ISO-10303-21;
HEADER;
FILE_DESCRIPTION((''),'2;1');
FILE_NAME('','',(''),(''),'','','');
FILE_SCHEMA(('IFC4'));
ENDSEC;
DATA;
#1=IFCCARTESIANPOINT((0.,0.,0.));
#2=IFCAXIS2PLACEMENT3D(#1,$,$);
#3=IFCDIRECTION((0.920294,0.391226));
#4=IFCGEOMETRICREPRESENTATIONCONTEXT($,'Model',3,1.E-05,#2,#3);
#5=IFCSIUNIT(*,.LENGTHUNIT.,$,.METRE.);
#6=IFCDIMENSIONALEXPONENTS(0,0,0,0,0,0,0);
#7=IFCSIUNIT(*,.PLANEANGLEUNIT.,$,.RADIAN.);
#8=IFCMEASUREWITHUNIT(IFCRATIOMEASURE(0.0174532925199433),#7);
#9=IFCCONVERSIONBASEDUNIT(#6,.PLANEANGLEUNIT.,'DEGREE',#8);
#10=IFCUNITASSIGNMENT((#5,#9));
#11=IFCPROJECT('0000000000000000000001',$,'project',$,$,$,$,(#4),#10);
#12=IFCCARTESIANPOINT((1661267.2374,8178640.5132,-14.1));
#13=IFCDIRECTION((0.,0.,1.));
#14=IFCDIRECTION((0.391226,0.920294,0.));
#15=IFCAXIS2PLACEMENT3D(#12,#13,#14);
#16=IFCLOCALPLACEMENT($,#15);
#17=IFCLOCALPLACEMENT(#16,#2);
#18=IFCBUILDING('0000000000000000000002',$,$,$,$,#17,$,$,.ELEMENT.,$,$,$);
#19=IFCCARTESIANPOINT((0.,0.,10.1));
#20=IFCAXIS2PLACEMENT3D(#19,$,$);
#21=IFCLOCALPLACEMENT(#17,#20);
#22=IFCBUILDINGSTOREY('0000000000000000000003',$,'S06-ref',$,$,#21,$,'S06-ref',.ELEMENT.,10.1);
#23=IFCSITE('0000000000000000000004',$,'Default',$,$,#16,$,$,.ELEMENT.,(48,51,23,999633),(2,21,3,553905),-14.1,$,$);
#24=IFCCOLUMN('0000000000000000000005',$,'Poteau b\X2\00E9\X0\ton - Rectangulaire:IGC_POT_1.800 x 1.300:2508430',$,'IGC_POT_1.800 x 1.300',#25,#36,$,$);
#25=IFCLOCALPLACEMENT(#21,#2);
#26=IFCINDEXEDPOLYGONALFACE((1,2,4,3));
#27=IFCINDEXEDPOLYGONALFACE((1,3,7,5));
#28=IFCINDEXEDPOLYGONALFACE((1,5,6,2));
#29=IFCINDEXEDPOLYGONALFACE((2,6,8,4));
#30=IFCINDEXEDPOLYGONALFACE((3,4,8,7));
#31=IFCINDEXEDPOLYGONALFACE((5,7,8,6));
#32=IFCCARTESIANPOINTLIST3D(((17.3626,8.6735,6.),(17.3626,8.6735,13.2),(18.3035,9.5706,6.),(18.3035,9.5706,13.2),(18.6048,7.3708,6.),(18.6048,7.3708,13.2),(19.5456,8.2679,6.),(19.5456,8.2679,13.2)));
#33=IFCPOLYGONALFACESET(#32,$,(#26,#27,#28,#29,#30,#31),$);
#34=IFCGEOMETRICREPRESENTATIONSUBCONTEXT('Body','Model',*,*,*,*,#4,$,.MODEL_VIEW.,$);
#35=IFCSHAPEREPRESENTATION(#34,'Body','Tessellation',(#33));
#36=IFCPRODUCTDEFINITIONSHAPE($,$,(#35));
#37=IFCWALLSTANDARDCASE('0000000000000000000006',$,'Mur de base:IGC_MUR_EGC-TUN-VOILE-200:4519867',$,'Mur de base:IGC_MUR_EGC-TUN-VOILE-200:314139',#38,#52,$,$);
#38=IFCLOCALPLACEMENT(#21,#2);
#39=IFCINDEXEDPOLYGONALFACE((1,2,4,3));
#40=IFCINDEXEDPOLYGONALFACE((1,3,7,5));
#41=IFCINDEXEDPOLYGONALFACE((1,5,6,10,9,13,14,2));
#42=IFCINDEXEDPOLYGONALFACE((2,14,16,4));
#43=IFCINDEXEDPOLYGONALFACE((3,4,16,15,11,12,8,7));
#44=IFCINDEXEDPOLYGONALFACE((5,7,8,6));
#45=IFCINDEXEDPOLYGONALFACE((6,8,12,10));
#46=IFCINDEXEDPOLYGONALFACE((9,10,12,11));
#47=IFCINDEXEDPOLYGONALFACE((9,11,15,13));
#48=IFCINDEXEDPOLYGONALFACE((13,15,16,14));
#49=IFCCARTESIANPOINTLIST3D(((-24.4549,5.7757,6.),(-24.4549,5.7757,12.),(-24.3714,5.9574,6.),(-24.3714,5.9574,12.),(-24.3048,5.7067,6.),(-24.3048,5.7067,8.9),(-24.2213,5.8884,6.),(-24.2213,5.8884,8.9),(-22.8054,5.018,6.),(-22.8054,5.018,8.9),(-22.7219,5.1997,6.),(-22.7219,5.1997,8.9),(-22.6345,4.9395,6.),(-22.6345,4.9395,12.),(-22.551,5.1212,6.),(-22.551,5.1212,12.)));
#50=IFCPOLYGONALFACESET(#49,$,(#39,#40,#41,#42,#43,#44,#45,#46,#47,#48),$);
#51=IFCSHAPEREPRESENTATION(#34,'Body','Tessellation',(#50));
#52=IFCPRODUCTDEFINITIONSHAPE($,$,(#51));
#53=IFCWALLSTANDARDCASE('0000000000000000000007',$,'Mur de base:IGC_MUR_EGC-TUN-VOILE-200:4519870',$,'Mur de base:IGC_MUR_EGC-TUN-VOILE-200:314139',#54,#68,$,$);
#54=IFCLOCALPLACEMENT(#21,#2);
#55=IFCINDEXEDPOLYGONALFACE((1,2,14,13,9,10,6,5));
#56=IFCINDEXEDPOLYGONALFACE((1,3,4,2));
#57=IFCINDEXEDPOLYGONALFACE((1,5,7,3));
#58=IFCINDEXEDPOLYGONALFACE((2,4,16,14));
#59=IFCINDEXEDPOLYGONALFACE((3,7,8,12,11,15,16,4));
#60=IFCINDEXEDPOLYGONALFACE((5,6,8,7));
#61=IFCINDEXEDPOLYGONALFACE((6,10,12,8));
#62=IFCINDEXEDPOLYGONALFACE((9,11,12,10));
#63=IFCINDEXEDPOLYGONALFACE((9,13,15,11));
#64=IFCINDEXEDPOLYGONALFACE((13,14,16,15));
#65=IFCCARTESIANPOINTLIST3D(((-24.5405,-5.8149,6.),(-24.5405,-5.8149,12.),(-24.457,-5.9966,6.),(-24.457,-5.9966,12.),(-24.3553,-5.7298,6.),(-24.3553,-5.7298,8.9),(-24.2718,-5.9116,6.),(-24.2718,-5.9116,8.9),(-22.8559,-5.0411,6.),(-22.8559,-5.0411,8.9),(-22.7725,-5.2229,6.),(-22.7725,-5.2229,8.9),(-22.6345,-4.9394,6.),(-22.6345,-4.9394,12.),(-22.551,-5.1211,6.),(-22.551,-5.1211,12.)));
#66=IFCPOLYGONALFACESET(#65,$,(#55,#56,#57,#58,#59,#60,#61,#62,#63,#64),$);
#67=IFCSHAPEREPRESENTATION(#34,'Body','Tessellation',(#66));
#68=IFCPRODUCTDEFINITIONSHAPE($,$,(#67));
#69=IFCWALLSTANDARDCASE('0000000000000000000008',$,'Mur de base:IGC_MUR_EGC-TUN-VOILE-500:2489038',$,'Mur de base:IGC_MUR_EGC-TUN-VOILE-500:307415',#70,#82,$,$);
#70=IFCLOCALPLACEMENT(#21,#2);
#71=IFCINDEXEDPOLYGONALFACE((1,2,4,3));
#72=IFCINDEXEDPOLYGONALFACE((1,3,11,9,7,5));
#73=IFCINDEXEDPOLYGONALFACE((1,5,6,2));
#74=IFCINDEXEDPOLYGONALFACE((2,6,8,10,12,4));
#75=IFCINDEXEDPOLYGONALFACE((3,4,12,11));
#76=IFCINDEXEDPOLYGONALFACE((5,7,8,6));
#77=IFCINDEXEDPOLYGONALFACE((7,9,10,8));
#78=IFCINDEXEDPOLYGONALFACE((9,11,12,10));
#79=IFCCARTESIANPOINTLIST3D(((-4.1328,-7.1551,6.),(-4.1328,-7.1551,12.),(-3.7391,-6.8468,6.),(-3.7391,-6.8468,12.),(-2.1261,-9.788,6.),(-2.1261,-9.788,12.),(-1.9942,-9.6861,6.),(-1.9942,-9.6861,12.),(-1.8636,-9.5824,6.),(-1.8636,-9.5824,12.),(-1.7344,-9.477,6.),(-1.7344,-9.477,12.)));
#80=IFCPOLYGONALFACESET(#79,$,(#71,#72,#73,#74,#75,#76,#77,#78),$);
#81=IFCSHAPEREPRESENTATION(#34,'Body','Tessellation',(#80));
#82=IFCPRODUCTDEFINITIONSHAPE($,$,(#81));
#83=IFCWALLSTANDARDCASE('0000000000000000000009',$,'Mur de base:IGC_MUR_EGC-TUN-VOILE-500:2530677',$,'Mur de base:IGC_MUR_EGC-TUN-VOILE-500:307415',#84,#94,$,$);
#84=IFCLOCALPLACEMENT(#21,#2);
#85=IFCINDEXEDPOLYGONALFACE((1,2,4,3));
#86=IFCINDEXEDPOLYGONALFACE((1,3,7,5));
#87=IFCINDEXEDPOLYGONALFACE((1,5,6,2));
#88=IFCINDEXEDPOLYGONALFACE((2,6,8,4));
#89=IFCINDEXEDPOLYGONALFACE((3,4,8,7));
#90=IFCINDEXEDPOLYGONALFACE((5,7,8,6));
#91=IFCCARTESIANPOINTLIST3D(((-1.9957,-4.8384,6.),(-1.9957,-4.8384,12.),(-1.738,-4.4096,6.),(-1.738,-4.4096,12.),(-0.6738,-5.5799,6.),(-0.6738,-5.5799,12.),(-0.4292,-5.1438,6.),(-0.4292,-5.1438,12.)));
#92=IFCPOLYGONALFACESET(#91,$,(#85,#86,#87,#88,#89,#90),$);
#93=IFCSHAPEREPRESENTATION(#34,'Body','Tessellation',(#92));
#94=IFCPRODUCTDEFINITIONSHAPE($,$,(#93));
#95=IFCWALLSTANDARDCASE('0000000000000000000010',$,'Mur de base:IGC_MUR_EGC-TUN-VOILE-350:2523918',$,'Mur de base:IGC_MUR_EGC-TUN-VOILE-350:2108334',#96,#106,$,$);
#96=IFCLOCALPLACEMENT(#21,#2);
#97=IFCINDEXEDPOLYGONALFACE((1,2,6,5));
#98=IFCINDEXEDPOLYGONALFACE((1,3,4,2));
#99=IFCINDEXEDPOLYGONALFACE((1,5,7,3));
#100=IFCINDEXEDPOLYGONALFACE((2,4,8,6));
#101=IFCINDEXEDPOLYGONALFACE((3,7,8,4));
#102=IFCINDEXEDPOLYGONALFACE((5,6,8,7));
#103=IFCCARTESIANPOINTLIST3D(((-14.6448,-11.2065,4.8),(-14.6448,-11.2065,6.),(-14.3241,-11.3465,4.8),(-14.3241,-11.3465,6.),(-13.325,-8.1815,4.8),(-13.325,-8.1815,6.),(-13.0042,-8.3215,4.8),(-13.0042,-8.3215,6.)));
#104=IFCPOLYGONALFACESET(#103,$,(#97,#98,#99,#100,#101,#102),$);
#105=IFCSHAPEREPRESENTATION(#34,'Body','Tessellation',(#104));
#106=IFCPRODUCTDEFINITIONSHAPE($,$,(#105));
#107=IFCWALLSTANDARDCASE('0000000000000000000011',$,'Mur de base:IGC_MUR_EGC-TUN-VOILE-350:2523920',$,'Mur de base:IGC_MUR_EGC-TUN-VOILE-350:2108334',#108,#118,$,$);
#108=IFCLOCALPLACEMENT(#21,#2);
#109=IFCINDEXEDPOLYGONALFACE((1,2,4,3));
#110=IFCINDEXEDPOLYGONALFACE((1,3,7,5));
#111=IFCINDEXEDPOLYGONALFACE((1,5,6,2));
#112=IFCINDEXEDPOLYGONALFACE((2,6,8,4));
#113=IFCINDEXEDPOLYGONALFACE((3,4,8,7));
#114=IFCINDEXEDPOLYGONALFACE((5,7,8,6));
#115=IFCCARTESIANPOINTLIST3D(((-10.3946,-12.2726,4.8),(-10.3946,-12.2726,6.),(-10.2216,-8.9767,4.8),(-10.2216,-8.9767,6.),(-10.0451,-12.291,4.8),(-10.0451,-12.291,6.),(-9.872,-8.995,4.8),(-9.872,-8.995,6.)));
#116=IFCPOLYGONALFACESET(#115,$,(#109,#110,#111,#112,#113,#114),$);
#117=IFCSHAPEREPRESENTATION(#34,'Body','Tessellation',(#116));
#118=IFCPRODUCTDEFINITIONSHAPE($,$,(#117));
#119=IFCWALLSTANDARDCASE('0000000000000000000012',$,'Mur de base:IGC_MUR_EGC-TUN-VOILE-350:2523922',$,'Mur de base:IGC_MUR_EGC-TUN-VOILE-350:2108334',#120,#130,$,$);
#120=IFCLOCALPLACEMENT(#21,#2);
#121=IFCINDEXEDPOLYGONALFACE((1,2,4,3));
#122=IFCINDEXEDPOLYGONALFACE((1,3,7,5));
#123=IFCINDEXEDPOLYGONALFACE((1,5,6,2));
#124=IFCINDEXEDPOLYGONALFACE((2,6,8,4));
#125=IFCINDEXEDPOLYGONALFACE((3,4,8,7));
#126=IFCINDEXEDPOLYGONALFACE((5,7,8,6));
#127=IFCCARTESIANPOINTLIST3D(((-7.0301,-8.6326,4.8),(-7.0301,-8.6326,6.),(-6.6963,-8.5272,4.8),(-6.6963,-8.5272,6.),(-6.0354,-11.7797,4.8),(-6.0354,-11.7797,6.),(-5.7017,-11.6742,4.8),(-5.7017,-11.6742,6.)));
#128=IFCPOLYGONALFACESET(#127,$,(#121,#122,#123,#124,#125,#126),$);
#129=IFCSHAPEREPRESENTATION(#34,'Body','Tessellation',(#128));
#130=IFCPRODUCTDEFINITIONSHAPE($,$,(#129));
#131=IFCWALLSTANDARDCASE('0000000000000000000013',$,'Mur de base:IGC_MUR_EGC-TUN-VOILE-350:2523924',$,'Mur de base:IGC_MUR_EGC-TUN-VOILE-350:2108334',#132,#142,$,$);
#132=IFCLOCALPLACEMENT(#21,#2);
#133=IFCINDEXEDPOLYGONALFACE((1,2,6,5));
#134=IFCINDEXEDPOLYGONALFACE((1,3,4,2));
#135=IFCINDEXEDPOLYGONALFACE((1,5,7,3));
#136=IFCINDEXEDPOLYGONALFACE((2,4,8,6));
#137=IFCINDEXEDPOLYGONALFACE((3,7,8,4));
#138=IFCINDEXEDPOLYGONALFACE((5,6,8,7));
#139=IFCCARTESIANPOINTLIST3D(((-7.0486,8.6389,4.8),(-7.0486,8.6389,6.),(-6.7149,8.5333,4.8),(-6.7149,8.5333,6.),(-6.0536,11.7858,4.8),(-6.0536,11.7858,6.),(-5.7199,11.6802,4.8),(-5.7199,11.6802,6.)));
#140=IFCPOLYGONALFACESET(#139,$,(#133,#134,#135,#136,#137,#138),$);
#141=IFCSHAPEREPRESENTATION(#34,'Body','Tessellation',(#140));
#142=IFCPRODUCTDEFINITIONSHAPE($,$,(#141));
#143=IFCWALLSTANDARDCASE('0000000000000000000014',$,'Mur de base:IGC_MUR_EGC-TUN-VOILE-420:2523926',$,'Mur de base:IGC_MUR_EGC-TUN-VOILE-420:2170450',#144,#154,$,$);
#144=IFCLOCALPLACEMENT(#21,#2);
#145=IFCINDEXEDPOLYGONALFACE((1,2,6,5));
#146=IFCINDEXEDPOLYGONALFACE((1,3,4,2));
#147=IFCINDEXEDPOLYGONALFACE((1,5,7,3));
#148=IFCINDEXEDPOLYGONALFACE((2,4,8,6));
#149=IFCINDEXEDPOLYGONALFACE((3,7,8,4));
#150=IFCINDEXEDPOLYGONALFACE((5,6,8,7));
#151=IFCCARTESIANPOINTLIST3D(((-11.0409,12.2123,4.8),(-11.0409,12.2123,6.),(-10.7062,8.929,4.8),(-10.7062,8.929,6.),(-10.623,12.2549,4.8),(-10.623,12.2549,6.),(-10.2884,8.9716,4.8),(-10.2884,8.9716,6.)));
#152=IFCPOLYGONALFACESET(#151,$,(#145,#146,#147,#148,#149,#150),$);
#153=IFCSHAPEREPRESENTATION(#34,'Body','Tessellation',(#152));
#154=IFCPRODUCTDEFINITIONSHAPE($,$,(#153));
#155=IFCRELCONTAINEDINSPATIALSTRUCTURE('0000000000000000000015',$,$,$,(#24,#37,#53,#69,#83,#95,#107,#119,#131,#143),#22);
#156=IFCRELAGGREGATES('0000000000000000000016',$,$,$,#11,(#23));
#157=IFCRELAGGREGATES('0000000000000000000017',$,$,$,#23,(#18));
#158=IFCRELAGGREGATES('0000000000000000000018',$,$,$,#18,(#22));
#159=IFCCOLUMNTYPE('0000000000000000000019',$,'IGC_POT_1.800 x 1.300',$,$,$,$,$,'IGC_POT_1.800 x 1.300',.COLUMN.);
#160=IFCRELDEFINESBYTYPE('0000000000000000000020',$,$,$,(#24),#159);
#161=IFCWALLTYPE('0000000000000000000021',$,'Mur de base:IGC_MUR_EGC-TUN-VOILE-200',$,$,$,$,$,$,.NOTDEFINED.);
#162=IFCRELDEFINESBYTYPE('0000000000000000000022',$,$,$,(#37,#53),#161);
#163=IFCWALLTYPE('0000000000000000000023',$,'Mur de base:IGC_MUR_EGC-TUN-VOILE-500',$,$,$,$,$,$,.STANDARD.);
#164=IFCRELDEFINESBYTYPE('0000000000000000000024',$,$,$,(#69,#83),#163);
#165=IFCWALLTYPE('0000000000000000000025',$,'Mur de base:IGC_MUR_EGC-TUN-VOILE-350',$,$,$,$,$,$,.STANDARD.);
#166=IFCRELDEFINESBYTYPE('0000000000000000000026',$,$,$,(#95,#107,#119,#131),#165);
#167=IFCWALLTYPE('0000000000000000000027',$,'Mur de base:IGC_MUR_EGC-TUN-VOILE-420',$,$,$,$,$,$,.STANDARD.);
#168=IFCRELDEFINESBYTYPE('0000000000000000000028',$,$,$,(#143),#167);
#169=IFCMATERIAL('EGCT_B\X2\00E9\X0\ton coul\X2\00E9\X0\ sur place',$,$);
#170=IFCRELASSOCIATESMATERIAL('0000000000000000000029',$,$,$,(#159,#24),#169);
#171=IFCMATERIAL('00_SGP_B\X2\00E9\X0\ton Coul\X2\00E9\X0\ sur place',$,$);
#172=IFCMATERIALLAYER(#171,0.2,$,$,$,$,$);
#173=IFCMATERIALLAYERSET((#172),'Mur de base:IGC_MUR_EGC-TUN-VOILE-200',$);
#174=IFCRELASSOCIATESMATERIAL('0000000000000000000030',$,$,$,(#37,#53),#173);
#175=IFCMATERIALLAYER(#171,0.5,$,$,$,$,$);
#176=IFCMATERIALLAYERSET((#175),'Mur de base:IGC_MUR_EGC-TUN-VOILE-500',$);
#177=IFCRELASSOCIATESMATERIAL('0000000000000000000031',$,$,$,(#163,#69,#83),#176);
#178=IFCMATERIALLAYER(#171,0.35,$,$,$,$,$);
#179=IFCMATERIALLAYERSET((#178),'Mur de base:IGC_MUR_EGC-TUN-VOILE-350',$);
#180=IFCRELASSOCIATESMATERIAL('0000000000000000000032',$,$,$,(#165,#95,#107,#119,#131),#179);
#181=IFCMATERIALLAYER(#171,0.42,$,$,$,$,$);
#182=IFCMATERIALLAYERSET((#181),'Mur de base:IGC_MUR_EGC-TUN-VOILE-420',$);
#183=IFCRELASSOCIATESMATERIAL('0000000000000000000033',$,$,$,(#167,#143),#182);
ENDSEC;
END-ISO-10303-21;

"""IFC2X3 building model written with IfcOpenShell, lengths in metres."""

from ifc_helpers import new_model, entity, si_unit, converted_unit, direction, frame, frame_2d, origin, place, context, subcontext, project, spatial, polyline, circle_curve, parameter, trimmed, segment, composite_curve, rectangle, outline, extrude, clip, bounded_halfspace, source, transform, mapped, material, layer, layer_set, layer_usage, type_object, type_shapes, element, save


model = new_model("IFC2X3")

# Units and contexts
model_context = context("Model", 3, precision=1e-05, world=origin(), true_north=direction((0.920294, 0.391226)))
body_context = subcontext(model_context, "Body", "Model", "MODEL_VIEW")
ifc_project = project(units=[si_unit("LENGTHUNIT", "METRE"), converted_unit("PLANEANGLEUNIT", "DEGREE", entity("IfcRatioMeasure", 0.0174532925199433), si_unit("PLANEANGLEUNIT", "RADIAN"), dimensions=[0, 0, 0, 0, 0, 0, 0])], contexts=[model_context])

# Site, building, storey
site_placement = place(None, frame((1661267.2374, 8178640.5132, -14.1), z_axis=(0.0, 0.0, 1.0), x_axis=(0.391226, 0.920294, 0.0)))
site = spatial("IfcSite", under=ifc_project, at=site_placement, Name="Default", CompositionType="ELEMENT", RefLatitude=(48, 51, 23, 999633), RefLongitude=(2, 21, 3, 553905), RefElevation=-14.1)
building_placement = place(site_placement, origin())
building = spatial("IfcBuilding", under=site, at=building_placement, CompositionType="ELEMENT")
storey_placement = place(building_placement, frame((0.0, 0.0, 10.1)))
storey = spatial("IfcBuildingStorey", under=building, at=storey_placement, Name="S06-ref", LongName="S06-ref", CompositionType="ELEMENT", Elevation=10.1)

# Column
ifc_material_1 = material(Name="EGCT_Béton coulé sur place")
column_type_1 = type_object("IfcColumnType", Name="IGC_POT_1.800 x 1.300", ElementType="IGC_POT_1.800 x 1.300", PredefinedType="COLUMN", material=ifc_material_1)
shared_shape_1 = source(origin(), body_context, "Body", "SweptSolid", [
    extrude(rectangle(XDim=1.8, YDim=1.3, at=frame_2d((0.0, 0.0), x_axis=(1.0, 0.0))), frame((18.4541, 8.4707, 16.1), z_axis=(0.0, 0.0, 1.0), x_axis=(-0.690086, 0.723727, 0.0)), (0.0, 0.0, 1.0), 7.2),
])
type_shapes(column_type_1, [shared_shape_1])
column_1_placement = place(storey_placement, frame((0.0, 0.0, -10.1)))
element("IfcColumn", 1, at=column_1_placement, inside=storey, type_object=column_type_1, material=ifc_material_1, Name="Poteau béton - Rectangulaire:IGC_POT_1.800 x 1.300:2508430", ObjectType="IGC_POT_1.800 x 1.300", context=body_context, shape_type="MappedRepresentation", body=[
    mapped(shared_shape_1, transform((0.0, 0.0, 0.0), scale=1.0)),
])

# Shared definitions
ifc_material_2 = material(Name="00_SGP_Béton Coulé sur place")
ifc_layer_1 = layer(ifc_material_2, 0.2)
ifc_layer_set_1 = layer_set([ifc_layer_1], Name="Mur de base:IGC_MUR_EGC-TUN-VOILE-200")
wall_type_1 = type_object("IfcWallType", Name="Mur de base:IGC_MUR_EGC-TUN-VOILE-200", PredefinedType="NOTDEFINED")

# Walls, openings
ifc_layer_usage_1 = layer_usage(ifc_layer_set_1, "AXIS2", "POSITIVE", -0.1)
wall_1_placement = place(storey_placement, frame((-22.5927, 5.0303, 6.0), z_axis=(0.0, 0.0, 1.0), x_axis=(-0.908714, 0.417419, 0.0)))
wall_1 = element("IfcWallStandardCase", 2, at=wall_1_placement, inside=storey, type_object=wall_type_1, material=ifc_layer_usage_1, Name="Mur de base:IGC_MUR_EGC-TUN-VOILE-200:4519867", ObjectType="Mur de base:IGC_MUR_EGC-TUN-VOILE-200:314139", context=body_context, shape_type="SweptSolid", body=[
    extrude(rectangle(XDim=2.0033, YDim=0.2, at=frame_2d((1.0016, 0.0), x_axis=(-1.0, 0.0))), origin(), (0.0, 0.0, 1.0), 6.0),
])
opening_1_placement = place(wall_1_placement, origin())
element("IfcOpeningElement", 3, at=opening_1_placement, cuts=wall_1, ObjectType="Opening", context=body_context, shape_type="SweptSolid", body=[
    extrude(rectangle(XDim=2.9, YDim=1.65, at=frame_2d((0.0, 0.0), x_axis=(1.0, 0.0))), frame((1.0131, -1.424, 1.45), z_axis=(0.0, 1.0, 0.0), x_axis=(0.0, 0.0, -1.0)), (0.0, 0.0, 1.0), 3.048),
])
ifc_layer_usage_2 = layer_usage(ifc_layer_set_1, "AXIS2", "NEGATIVE", 0.1)
wall_2_placement = place(storey_placement, frame((-22.5927, -5.0302, 6.0), z_axis=(0.0, 0.0, 1.0), x_axis=(-0.908714, -0.417419, 0.0)))
wall_2 = element("IfcWallStandardCase", 4, at=wall_2_placement, inside=storey, type_object=wall_type_1, material=ifc_layer_usage_2, Name="Mur de base:IGC_MUR_EGC-TUN-VOILE-200:4519870", ObjectType="Mur de base:IGC_MUR_EGC-TUN-VOILE-200:314139", context=body_context, shape_type="SweptSolid", body=[
    extrude(rectangle(XDim=2.0974, YDim=0.2, at=frame_2d((1.0487, 0.0), x_axis=(-1.0, 0.0))), origin(), (0.0, 0.0, 1.0), 6.0),
])
opening_2_placement = place(wall_2_placement, origin())
element("IfcOpeningElement", 5, at=opening_2_placement, cuts=wall_2, ObjectType="Opening", context=body_context, shape_type="SweptSolid", body=[
    extrude(rectangle(XDim=2.9, YDim=1.65, at=frame_2d((0.0, 0.0), x_axis=(0.0, 1.0))), frame((1.0687, -1.624, 1.45), z_axis=(0.0, 1.0, 0.0), x_axis=(1.0, 0.0, 0.0)), (0.0, 0.0, 1.0), 3.048),
])

# Shared definitions
ifc_layer_2 = layer(ifc_material_2, 0.5)
ifc_layer_set_2 = layer_set([ifc_layer_2], Name="Mur de base:IGC_MUR_EGC-TUN-VOILE-500")
wall_type_2 = type_object("IfcWallType", Name="Mur de base:IGC_MUR_EGC-TUN-VOILE-500", PredefinedType="STANDARD", material=ifc_layer_set_2)

# Walls
ifc_layer_usage_3 = layer_usage(ifc_layer_set_2, "AXIS2", "NEGATIVE", 0.25)
wall_3_placement = place(storey_placement, frame((-1.9273, -9.6364, 6.0), z_axis=(0.0, 0.0, 1.0), x_axis=(-0.606175, 0.795331, 0.0)))
element("IfcWallStandardCase", 6, at=wall_3_placement, inside=storey, type_object=wall_type_2, material=ifc_layer_usage_3, Name="Mur de base:IGC_MUR_EGC-TUN-VOILE-500:2489038", ObjectType="Mur de base:IGC_MUR_EGC-TUN-VOILE-500:307415", context=body_context, shape_type="Clipping", body=[
    clip(extrude(outline(composite_curve([segment(polyline([(0.0099, -0.25), (3.317, -0.25)]), True, "CONTINUOUS"), segment(polyline([(3.317, -0.25), (3.3104, 0.25)]), True, "CONTINUOUS"), segment(polyline([(3.3104, 0.25), (0.0, 0.25)]), True, "CONTINUOUS"), segment(trimmed(circle_curve(frame_2d((12.3, 0.2435), x_axis=(-0.606175, -0.795331)), 12.3), [parameter(307.283202)], [parameter(309.612919)], True, "PARAMETER"), True, "CONTINUOUS")], self_intersect=False)), origin(), (0.0, 0.0, 1.0), 6.0), bounded_halfspace(frame((3.317, -0.25, 6.0), z_axis=(-0.999912, -0.013234, 0.0), x_axis=(0.0, 0.0, -1.0)), True, frame((3.317, -0.25, 6.0), z_axis=(-0.999912, -0.013234, 0.0), x_axis=(0.0, 0.0, -1.0)), polyline([(0.0, 0.0), (0.0, -0.5), (6.0, -0.5), (6.0, 0.0), (0.0, 0.0)]))),
])
ifc_layer_usage_4 = layer_usage(ifc_layer_set_2, "AXIS2", "NEGATIVE", 0.25)
wall_4_placement = place(storey_placement, frame((-0.5515, -5.3618, 6.0), z_axis=(0.0, 0.0, 1.0), x_axis=(-0.872153, 0.489234, 0.0)))
element("IfcWallStandardCase", 7, at=wall_4_placement, inside=storey, type_object=wall_type_2, material=ifc_layer_usage_4, Name="Mur de base:IGC_MUR_EGC-TUN-VOILE-500:2530677", ObjectType="Mur de base:IGC_MUR_EGC-TUN-VOILE-500:307415", context=body_context, shape_type="Clipping", body=[
    clip(extrude(rectangle(XDim=1.5156, YDim=0.5, at=frame_2d((0.7578, 0.0), x_axis=(-1.0, 0.0))), origin(), (0.0, 0.0, 1.0), 6.0), bounded_halfspace(frame((1.5007, -0.25, 6.0), z_axis=(-0.999552, 0.029916, 0.0), x_axis=(0.0, 0.0, -1.0)), True, frame((1.5007, -0.25, 6.0), z_axis=(-0.999552, 0.029916, 0.0), x_axis=(0.0, 0.0, -1.0)), polyline([(0.0, 0.0), (0.0, -0.5002), (6.0, -0.5002), (6.0, 0.0), (0.0, 0.0)]))),
])
ifc_layer_3 = layer(ifc_material_2, 0.35)
ifc_layer_set_3 = layer_set([ifc_layer_3], Name="Mur de base:IGC_MUR_EGC-TUN-VOILE-350")
wall_type_3 = type_object("IfcWallType", Name="Mur de base:IGC_MUR_EGC-TUN-VOILE-350", PredefinedType="STANDARD", material=ifc_layer_set_3)
ifc_layer_usage_5 = layer_usage(ifc_layer_set_3, "AXIS2", "POSITIVE", -0.175)
wall_5_placement = place(storey_placement, frame((-13.1646, -8.2515, 4.8), z_axis=(0.0, 0.0, 1.0), x_axis=(-0.39991, -0.916554, 0.0)))
element("IfcWallStandardCase", 8, at=wall_5_placement, inside=storey, type_object=wall_type_3, material=ifc_layer_usage_5, Name="Mur de base:IGC_MUR_EGC-TUN-VOILE-350:2523918", ObjectType="Mur de base:IGC_MUR_EGC-TUN-VOILE-350:2108334", context=body_context, shape_type="SweptSolid", body=[
    extrude(rectangle(XDim=3.3004, YDim=0.35, at=frame_2d((1.6502, 0.0), x_axis=(-1.0, 0.0))), origin(), (0.0, 0.0, 1.0), 1.2),
])
ifc_layer_usage_6 = layer_usage(ifc_layer_set_3, "AXIS2", "POSITIVE", -0.175)
wall_6_placement = place(storey_placement, frame((-10.0468, -8.9859, 4.8), z_axis=(0.0, 0.0, 1.0), x_axis=(-0.052435, -0.998624, 0.0)))
element("IfcWallStandardCase", 9, at=wall_6_placement, inside=storey, type_object=wall_type_3, material=ifc_layer_usage_6, Name="Mur de base:IGC_MUR_EGC-TUN-VOILE-350:2523920", ObjectType="Mur de base:IGC_MUR_EGC-TUN-VOILE-350:2108334", context=body_context, shape_type="SweptSolid", body=[
    extrude(rectangle(XDim=3.3005, YDim=0.35, at=frame_2d((1.6502, 0.0), x_axis=(-1.0, 0.0))), origin(), (0.0, 0.0, 1.0), 1.2),
])
ifc_layer_usage_7 = layer_usage(ifc_layer_set_3, "AXIS2", "POSITIVE", -0.175)
wall_7_placement = place(storey_placement, frame((-6.8632, -8.5799, 4.8), z_axis=(0.0, 0.0, 1.0), x_axis=(0.301365, -0.953509, 0.0)))
element("IfcWallStandardCase", 10, at=wall_7_placement, inside=storey, type_object=wall_type_3, material=ifc_layer_usage_7, Name="Mur de base:IGC_MUR_EGC-TUN-VOILE-350:2523922", ObjectType="Mur de base:IGC_MUR_EGC-TUN-VOILE-350:2108334", context=body_context, shape_type="SweptSolid", body=[
    extrude(rectangle(XDim=3.3005, YDim=0.35, at=frame_2d((1.6502, 0.0), x_axis=(-1.0, 0.0))), origin(), (0.0, 0.0, 1.0), 1.2),
])
ifc_layer_usage_8 = layer_usage(ifc_layer_set_3, "AXIS2", "POSITIVE", -0.175)
wall_8_placement = place(storey_placement, frame((-6.8817, 8.5861, 4.8), z_axis=(0.0, 0.0, 1.0), x_axis=(0.301469, 0.953476, 0.0)))
element("IfcWallStandardCase", 11, at=wall_8_placement, inside=storey, type_object=wall_type_3, material=ifc_layer_usage_8, Name="Mur de base:IGC_MUR_EGC-TUN-VOILE-350:2523924", ObjectType="Mur de base:IGC_MUR_EGC-TUN-VOILE-350:2108334", context=body_context, shape_type="SweptSolid", body=[
    extrude(rectangle(XDim=3.3004, YDim=0.35, at=frame_2d((1.6502, 0.0), x_axis=(-1.0, 0.0))), origin(), (0.0, 0.0, 1.0), 1.2),
])
ifc_layer_4 = layer(ifc_material_2, 0.42)
ifc_layer_set_4 = layer_set([ifc_layer_4], Name="Mur de base:IGC_MUR_EGC-TUN-VOILE-420")
ifc_layer_usage_9 = layer_usage(ifc_layer_set_4, "AXIS2", "POSITIVE", -0.21)
wall_type_4 = type_object("IfcWallType", Name="Mur de base:IGC_MUR_EGC-TUN-VOILE-420", PredefinedType="STANDARD", material=ifc_layer_set_4)
wall_9_placement = place(storey_placement, frame((-10.4973, 8.9503, 4.8), z_axis=(0.0, 0.0, 1.0), x_axis=(-0.101398, 0.994846, 0.0)))
element("IfcWallStandardCase", 12, at=wall_9_placement, inside=storey, type_object=wall_type_4, material=ifc_layer_usage_9, Name="Mur de base:IGC_MUR_EGC-TUN-VOILE-420:2523926", ObjectType="Mur de base:IGC_MUR_EGC-TUN-VOILE-420:2170450", context=body_context, shape_type="SweptSolid", body=[
    extrude(rectangle(XDim=3.3003, YDim=0.42, at=frame_2d((1.6502, 0.0), x_axis=(-1.0, 0.0))), origin(), (0.0, 0.0, 1.0), 1.2),
])

save(model, "model.ifc")
